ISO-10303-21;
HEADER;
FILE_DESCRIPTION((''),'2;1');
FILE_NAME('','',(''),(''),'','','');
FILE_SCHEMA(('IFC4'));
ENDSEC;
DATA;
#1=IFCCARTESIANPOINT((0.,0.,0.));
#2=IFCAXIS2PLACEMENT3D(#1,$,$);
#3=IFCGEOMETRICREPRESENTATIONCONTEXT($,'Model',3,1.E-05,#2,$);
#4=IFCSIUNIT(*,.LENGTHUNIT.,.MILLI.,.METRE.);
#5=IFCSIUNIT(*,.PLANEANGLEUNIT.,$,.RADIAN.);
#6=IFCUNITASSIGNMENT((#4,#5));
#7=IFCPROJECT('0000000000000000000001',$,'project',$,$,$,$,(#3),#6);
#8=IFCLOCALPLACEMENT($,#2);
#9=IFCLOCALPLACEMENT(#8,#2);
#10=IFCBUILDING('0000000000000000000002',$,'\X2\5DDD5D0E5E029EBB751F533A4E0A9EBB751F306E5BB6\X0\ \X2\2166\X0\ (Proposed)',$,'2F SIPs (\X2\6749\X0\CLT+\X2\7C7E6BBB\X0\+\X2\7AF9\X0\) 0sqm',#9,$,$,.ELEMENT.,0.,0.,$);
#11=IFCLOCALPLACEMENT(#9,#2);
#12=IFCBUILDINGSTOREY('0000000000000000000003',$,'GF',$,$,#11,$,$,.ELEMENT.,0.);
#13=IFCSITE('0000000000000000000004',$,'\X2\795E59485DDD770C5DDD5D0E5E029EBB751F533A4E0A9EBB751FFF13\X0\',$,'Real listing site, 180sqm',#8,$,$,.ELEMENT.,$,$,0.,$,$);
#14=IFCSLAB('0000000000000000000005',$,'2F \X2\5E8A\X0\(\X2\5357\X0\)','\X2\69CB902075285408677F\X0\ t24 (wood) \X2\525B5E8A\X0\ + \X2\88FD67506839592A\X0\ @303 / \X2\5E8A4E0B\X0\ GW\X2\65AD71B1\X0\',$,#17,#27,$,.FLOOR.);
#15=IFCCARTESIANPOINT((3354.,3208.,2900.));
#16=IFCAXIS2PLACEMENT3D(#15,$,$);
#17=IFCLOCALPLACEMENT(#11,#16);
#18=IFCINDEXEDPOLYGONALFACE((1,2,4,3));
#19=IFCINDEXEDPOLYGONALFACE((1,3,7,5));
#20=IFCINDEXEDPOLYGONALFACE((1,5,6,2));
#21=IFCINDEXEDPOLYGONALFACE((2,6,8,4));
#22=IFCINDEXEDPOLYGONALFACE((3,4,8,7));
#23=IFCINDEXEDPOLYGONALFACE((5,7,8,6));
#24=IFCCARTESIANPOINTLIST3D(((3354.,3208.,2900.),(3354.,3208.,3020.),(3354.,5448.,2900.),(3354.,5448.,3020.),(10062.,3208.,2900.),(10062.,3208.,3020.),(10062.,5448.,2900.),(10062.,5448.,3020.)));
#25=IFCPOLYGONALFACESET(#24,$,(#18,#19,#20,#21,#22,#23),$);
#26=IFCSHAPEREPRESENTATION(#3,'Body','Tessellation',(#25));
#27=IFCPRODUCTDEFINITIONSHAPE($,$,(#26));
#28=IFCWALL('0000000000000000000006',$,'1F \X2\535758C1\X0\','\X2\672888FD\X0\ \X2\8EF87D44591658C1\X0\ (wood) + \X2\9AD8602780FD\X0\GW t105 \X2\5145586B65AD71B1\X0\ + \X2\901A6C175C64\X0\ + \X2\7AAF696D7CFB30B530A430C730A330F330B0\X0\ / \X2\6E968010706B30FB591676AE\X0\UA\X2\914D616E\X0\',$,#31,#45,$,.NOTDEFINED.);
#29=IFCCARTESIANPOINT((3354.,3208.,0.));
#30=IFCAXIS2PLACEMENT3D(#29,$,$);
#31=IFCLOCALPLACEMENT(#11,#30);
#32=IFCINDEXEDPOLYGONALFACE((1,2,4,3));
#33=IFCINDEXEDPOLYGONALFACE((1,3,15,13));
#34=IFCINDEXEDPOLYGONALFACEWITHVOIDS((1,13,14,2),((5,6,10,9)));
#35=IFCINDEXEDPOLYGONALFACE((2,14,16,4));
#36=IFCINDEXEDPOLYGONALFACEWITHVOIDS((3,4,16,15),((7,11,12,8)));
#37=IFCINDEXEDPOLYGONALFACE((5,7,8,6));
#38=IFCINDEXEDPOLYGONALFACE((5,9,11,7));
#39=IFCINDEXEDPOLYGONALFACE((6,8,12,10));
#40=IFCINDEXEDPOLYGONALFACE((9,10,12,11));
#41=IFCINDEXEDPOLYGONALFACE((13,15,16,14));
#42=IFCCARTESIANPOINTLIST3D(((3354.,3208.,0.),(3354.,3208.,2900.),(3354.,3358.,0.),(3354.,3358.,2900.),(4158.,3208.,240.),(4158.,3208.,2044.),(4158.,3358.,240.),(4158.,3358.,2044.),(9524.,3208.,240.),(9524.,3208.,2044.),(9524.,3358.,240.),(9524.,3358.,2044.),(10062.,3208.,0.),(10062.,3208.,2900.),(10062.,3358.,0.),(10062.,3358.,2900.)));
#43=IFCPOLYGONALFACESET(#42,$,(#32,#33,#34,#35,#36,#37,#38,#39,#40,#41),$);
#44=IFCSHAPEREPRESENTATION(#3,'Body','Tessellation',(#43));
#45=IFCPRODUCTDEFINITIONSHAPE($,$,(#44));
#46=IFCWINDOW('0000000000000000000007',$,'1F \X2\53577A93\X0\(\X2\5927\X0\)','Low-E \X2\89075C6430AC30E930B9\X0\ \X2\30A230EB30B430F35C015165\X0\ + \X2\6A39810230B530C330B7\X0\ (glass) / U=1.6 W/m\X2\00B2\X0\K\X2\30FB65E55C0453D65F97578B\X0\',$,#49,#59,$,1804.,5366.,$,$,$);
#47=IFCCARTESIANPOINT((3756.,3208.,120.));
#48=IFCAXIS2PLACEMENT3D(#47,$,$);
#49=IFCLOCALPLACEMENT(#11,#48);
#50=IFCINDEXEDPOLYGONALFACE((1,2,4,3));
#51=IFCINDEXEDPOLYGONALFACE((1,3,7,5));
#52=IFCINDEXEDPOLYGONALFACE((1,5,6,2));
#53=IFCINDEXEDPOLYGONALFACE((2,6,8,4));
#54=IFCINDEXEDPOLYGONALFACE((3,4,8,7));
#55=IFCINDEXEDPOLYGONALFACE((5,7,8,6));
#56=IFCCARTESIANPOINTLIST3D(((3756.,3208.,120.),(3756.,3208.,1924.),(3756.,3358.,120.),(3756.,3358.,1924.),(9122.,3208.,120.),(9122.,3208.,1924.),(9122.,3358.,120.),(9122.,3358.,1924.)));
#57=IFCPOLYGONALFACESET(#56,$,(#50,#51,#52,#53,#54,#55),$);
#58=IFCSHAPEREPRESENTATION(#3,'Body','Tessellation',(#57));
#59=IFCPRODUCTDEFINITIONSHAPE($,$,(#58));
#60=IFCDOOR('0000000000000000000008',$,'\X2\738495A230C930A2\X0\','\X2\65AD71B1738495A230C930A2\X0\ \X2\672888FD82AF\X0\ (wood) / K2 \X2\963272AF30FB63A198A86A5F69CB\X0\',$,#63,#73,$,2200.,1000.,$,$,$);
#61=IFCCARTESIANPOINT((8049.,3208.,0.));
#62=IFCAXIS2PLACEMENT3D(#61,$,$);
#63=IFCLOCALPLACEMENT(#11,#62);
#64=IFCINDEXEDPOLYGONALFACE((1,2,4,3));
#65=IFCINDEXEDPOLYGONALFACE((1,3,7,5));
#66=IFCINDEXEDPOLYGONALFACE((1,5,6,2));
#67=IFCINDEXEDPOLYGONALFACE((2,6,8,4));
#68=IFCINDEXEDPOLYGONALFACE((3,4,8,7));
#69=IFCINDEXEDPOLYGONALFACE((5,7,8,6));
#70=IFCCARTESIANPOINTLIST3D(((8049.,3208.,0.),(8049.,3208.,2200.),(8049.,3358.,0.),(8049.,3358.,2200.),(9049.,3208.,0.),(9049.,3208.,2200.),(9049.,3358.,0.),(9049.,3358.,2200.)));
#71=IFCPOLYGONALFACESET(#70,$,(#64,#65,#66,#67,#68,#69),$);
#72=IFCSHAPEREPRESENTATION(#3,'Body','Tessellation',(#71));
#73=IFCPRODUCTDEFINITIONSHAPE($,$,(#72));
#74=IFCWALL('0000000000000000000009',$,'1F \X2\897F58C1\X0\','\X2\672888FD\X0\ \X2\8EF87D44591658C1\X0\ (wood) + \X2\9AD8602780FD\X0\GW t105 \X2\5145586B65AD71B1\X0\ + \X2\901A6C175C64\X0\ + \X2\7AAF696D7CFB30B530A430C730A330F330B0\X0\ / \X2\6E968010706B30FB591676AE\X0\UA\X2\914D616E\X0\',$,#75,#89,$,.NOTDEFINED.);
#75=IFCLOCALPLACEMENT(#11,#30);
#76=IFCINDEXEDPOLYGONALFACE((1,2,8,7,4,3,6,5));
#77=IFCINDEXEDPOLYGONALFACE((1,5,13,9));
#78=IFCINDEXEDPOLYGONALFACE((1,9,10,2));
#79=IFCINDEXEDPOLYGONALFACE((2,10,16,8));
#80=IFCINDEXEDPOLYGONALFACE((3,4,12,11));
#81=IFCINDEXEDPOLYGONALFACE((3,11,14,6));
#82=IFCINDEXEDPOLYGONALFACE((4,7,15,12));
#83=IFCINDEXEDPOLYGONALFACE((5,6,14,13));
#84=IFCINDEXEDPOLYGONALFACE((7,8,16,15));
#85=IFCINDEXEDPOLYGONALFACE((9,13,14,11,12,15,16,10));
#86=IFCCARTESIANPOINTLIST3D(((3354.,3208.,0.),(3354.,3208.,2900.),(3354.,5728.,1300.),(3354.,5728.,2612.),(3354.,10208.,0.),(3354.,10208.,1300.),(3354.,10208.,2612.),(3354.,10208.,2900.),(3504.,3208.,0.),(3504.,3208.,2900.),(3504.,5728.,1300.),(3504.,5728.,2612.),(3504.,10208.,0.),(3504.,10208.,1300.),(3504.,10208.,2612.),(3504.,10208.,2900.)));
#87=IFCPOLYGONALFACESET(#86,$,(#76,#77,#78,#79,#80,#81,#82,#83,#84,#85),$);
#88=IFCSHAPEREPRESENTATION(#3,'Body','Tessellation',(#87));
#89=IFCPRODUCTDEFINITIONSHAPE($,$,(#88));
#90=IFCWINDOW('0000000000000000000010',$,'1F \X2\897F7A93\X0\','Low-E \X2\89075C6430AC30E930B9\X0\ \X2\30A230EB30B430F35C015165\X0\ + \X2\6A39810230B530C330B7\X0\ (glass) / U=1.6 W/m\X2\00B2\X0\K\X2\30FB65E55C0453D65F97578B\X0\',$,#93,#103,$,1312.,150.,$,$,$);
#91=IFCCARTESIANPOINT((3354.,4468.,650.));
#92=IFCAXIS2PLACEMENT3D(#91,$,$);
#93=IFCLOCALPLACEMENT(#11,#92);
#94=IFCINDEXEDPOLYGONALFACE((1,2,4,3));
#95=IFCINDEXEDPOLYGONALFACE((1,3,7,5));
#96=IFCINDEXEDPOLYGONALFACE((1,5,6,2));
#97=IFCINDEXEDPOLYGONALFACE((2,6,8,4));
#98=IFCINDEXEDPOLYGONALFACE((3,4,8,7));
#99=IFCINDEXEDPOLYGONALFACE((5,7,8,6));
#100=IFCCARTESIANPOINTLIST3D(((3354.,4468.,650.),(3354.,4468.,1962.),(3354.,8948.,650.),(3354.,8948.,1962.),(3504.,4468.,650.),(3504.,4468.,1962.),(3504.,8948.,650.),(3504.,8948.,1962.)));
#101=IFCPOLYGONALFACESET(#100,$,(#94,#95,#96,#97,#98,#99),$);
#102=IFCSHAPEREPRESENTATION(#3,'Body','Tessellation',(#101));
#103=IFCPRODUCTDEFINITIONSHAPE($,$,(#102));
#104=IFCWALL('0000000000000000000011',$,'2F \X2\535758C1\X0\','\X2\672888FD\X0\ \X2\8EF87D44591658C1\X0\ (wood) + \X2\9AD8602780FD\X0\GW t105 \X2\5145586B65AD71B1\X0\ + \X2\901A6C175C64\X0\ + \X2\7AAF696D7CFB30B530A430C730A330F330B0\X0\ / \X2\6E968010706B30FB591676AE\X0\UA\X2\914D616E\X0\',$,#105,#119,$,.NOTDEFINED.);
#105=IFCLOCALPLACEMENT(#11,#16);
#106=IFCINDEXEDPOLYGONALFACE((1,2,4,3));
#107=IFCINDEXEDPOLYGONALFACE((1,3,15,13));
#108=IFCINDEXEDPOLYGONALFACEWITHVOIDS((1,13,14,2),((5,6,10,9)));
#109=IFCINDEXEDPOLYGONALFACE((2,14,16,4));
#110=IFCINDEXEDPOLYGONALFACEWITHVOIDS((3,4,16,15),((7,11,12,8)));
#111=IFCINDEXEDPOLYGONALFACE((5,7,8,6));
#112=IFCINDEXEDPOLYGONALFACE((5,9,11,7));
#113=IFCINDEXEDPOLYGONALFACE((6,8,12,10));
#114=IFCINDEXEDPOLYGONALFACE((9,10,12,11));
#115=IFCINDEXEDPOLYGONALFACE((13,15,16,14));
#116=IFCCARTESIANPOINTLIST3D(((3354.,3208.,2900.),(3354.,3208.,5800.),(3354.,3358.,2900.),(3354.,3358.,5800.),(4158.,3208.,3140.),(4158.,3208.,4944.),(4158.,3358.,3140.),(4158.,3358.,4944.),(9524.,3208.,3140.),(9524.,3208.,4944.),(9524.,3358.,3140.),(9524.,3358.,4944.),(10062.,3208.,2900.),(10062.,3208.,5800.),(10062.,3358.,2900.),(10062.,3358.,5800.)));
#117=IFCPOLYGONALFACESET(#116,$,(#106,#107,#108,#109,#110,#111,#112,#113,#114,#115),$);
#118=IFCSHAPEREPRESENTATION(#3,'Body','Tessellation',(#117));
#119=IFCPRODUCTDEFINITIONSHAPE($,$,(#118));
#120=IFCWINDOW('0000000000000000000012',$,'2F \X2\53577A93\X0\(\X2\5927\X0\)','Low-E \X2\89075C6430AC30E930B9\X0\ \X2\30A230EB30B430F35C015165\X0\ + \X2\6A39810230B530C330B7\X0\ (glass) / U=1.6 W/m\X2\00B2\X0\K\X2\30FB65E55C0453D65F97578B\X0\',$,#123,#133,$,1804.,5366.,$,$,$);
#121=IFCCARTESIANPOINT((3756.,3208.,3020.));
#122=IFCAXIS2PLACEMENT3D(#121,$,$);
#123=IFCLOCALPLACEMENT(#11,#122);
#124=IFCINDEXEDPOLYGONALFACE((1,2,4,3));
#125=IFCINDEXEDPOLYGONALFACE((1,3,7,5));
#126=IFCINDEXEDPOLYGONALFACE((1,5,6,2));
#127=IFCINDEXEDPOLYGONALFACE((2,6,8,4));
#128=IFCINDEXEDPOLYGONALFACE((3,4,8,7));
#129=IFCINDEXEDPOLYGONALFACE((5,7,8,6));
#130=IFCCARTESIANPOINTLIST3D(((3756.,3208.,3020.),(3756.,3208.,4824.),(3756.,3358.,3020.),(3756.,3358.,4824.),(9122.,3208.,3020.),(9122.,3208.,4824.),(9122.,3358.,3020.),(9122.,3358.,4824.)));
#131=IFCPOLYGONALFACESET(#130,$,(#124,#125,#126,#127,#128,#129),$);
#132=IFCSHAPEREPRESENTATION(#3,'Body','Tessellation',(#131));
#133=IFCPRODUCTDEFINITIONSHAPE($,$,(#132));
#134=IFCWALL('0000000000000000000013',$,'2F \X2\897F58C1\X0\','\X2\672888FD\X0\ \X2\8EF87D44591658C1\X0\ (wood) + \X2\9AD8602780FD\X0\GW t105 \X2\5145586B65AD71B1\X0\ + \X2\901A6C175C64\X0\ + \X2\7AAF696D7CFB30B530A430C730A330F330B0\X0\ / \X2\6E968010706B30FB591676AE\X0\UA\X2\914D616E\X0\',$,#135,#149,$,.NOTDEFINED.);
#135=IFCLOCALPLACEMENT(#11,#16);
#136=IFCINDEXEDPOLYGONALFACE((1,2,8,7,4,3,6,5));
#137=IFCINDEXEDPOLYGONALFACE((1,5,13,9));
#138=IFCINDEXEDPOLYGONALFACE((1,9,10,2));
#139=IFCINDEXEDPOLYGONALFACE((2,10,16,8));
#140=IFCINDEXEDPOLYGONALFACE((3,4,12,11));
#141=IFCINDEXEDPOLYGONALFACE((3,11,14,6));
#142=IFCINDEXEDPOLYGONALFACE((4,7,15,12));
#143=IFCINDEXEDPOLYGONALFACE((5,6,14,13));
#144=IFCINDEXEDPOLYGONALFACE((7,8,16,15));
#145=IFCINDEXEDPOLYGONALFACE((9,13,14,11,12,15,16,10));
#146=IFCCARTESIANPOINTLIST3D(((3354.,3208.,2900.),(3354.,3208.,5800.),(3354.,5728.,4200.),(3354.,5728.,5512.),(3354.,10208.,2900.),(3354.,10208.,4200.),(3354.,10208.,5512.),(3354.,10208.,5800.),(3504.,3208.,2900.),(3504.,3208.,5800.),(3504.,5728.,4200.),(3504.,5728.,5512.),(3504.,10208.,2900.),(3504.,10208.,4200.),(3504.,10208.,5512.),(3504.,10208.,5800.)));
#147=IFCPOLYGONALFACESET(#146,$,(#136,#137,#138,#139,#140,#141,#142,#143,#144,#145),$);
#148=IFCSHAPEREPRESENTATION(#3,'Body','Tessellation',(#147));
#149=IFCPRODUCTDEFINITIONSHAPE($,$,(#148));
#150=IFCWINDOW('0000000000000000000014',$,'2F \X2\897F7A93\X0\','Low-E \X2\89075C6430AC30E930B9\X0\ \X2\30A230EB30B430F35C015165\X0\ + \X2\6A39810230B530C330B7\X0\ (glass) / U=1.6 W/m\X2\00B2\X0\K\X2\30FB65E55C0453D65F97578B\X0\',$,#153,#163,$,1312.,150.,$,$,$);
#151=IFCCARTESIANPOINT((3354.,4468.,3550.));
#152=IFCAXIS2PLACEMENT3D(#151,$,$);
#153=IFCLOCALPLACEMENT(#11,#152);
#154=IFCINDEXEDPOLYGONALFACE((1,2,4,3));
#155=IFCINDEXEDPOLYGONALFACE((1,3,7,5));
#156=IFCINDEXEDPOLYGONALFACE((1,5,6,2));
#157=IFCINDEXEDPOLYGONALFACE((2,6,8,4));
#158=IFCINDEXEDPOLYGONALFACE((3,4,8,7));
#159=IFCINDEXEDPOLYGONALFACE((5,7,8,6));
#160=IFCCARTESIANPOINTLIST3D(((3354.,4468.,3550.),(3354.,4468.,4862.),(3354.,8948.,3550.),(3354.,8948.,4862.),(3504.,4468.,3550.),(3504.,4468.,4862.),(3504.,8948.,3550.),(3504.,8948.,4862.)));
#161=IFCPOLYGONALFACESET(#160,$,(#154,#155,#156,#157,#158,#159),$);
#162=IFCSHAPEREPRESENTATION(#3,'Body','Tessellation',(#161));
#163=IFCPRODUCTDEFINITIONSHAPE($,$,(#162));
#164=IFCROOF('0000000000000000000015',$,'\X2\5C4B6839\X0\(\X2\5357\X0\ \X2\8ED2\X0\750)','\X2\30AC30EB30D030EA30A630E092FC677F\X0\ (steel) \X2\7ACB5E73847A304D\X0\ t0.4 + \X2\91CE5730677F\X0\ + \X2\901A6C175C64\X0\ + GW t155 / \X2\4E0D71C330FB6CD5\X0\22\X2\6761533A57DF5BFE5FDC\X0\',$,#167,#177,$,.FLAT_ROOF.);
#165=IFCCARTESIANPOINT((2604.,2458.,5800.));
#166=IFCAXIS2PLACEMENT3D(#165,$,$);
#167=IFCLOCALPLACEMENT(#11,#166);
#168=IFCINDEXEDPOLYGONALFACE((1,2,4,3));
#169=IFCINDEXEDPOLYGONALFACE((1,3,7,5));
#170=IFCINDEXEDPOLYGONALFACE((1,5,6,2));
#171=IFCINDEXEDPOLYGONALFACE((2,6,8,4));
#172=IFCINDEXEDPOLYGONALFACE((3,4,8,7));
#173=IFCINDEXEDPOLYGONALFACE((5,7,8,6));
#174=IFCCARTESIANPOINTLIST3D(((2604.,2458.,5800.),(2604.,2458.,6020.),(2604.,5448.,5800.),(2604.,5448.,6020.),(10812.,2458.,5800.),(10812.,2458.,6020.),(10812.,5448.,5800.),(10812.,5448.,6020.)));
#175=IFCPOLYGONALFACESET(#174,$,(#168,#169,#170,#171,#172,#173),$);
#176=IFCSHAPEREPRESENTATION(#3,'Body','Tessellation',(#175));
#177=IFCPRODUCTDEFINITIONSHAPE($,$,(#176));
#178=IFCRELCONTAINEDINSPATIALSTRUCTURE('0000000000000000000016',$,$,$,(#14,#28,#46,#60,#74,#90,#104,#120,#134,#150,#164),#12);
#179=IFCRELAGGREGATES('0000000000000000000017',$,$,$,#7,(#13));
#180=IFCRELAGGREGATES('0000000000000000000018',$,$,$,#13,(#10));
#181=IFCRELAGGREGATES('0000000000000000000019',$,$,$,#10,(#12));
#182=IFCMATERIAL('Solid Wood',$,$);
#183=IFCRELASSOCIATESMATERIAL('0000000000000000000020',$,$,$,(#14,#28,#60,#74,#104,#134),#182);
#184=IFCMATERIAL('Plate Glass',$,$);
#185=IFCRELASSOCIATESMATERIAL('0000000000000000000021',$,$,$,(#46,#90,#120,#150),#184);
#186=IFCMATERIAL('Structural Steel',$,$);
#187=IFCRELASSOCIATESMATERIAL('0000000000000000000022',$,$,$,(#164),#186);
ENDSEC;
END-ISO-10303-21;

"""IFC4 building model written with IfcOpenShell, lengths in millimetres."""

from ifc_helpers import new_model, si_unit, frame, frame_2d, origin, place, context, project, spatial, rectangle, extrude, material, element, fill, save


model = new_model("IFC4")

# Units and contexts
model_context = context("Model", 3, precision=1e-05, world=origin())
ifc_project = project(units=[si_unit("LENGTHUNIT", "METRE", prefix="MILLI"), si_unit("PLANEANGLEUNIT", "RADIAN")], contexts=[model_context])

# Site, building, storey
site_placement = place(None, origin())
site = spatial("IfcSite", under=ifc_project, at=site_placement, Name="神奈川県川崎市麻生区上麻生３", ObjectType="Real listing site, 180sqm", CompositionType="ELEMENT", RefElevation=0.0)
building_placement = place(site_placement, origin())
building = spatial("IfcBuilding", under=site, at=building_placement, Name="川崎市麻生区上麻生の家 Ⅶ (Proposed)", ObjectType="2F SIPs (杉CLT+籾殻+竹) 0sqm", CompositionType="ELEMENT", ElevationOfRefHeight=0.0, ElevationOfTerrain=0.0)
storey_placement = place(building_placement, origin())
storey = spatial("IfcBuildingStorey", under=building, at=storey_placement, Name="GF", CompositionType="ELEMENT", Elevation=0.0)

# Slab
ifc_material_1 = material(Name="Solid Wood")
slab_1_placement = place(storey_placement, frame((3354.0, 3208.0, 2900.0)))
element("IfcSlab", 1, at=slab_1_placement, inside=storey, material=ifc_material_1, Name="2F 床(南)", Description="構造用合板 t24 (wood) 剛床 + 製材根太 @303 / 床下 GW断熱", PredefinedType="FLOOR", context=model_context, shape_type="SweptSolid", body=[
    extrude(rectangle(XDim=6708.0, YDim=2240.0, at=frame_2d((3354.0, 1120.0))), frame((3354.0, 3208.0, 2900.0)), (0.0, 0.0, 1.0), 120.0),
])

# Wall, openings, window, door
wall_1_placement = place(storey_placement, frame((3354.0, 3208.0, 0.0)))
wall_1 = element("IfcWall", 2, at=wall_1_placement, inside=storey, material=ifc_material_1, Name="1F 南壁", Description="木製 軸組外壁 (wood) + 高性能GW t105 充填断熱 + 通気層 + 窯業系サイディング / 準耐火・外皮UA配慮", PredefinedType="NOTDEFINED", context=model_context, shape_type="SweptSolid", body=[
    extrude(rectangle(XDim=6708.0, YDim=150.0, at=frame_2d((3354.0, 75.0))), frame((3354.0, 3208.0, 0.0)), (0.0, 0.0, 1.0), 2900.0),
])
opening_1_placement = place(storey_placement, frame((3756.0, 3208.0, 120.0)))
opening_1 = element("IfcOpeningElement", 3, at=opening_1_placement, cuts=wall_1, PredefinedType="NOTDEFINED", context=model_context, shape_type="SweptSolid", body=[
    extrude(rectangle(XDim=5366.0, YDim=150.0, at=frame_2d((2683.0, 75.0))), frame((3756.0, 3208.0, 120.0)), (0.0, 0.0, 1.0), 1804.0),
])
opening_2_placement = place(storey_placement, frame((8049.0, 3208.0, 0.0)))
opening_2 = element("IfcOpeningElement", 4, at=opening_2_placement, cuts=wall_1, PredefinedType="NOTDEFINED", context=model_context, shape_type="SweptSolid", body=[
    extrude(rectangle(XDim=1000.0, YDim=150.0, at=frame_2d((500.0, 75.0))), frame((8049.0, 3208.0, 0.0)), (0.0, 0.0, 1.0), 2200.0),
])
ifc_material_2 = material(Name="Plate Glass")
window_1_placement = place(storey_placement, frame((3756.0, 3208.0, 120.0)))
window_1 = element("IfcWindow", 5, at=window_1_placement, inside=storey, material=ifc_material_2, Name="1F 南窓(大)", Description="Low-E 複層ガラス アルゴン封入 + 樹脂サッシ (glass) / U=1.6 W/m²K・日射取得型", OverallHeight=1804.0, OverallWidth=5366.0, context=model_context, shape_type="SweptSolid", body=[
    extrude(rectangle(XDim=5366.0, YDim=150.0, at=frame_2d((2683.0, 75.0))), frame((3756.0, 3208.0, 120.0)), (0.0, 0.0, 1.0), 1804.0),
])
fill(opening_1, window_1)
door_placement = place(storey_placement, frame((8049.0, 3208.0, 0.0)))
door = element("IfcDoor", 6, at=door_placement, inside=storey, material=ifc_material_1, Name="玄関ドア", Description="断熱玄関ドア 木製芯 (wood) / K2 防犯・採風機構", OverallHeight=2200.0, OverallWidth=1000.0, context=model_context, shape_type="SweptSolid", body=[
    extrude(rectangle(XDim=1000.0, YDim=150.0, at=frame_2d((500.0, 75.0))), frame((8049.0, 3208.0, 0.0)), (0.0, 0.0, 1.0), 2200.0),
])
fill(opening_2, door)

# Walls, openings, windows
wall_2_placement = place(storey_placement, frame((3354.0, 3208.0, 0.0)))
wall_2 = element("IfcWall", 7, at=wall_2_placement, inside=storey, material=ifc_material_1, Name="1F 西壁", Description="木製 軸組外壁 (wood) + 高性能GW t105 充填断熱 + 通気層 + 窯業系サイディング / 準耐火・外皮UA配慮", PredefinedType="NOTDEFINED", context=model_context, shape_type="SweptSolid", body=[
    extrude(rectangle(XDim=150.0, YDim=7000.0, at=frame_2d((75.0, 3500.0))), frame((3354.0, 3208.0, 0.0)), (0.0, 0.0, 1.0), 2900.0),
])
opening_3_placement = place(storey_placement, frame((3354.0, 4468.0, 650.0)))
opening_3 = element("IfcOpeningElement", 8, at=opening_3_placement, cuts=wall_2, PredefinedType="NOTDEFINED", context=model_context, shape_type="SweptSolid", body=[
    extrude(rectangle(XDim=150.0, YDim=4480.0, at=frame_2d((75.0, 2240.0))), frame((3354.0, 4468.0, 650.0)), (0.0, 0.0, 1.0), 1312.0),
])
window_2_placement = place(storey_placement, frame((3354.0, 4468.0, 650.0)))
window_2 = element("IfcWindow", 9, at=window_2_placement, inside=storey, material=ifc_material_2, Name="1F 西窓", Description="Low-E 複層ガラス アルゴン封入 + 樹脂サッシ (glass) / U=1.6 W/m²K・日射取得型", OverallHeight=1312.0, OverallWidth=150.0, context=model_context, shape_type="SweptSolid", body=[
    extrude(rectangle(XDim=150.0, YDim=4480.0, at=frame_2d((75.0, 2240.0))), frame((3354.0, 4468.0, 650.0)), (0.0, 0.0, 1.0), 1312.0),
])
fill(opening_3, window_2)
wall_3_placement = place(storey_placement, frame((3354.0, 3208.0, 2900.0)))
wall_3 = element("IfcWall", 10, at=wall_3_placement, inside=storey, material=ifc_material_1, Name="2F 南壁", Description="木製 軸組外壁 (wood) + 高性能GW t105 充填断熱 + 通気層 + 窯業系サイディング / 準耐火・外皮UA配慮", PredefinedType="NOTDEFINED", context=model_context, shape_type="SweptSolid", body=[
    extrude(rectangle(XDim=6708.0, YDim=150.0, at=frame_2d((3354.0, 75.0))), frame((3354.0, 3208.0, 2900.0)), (0.0, 0.0, 1.0), 2900.0),
])
opening_4_placement = place(storey_placement, frame((3756.0, 3208.0, 3020.0)))
opening_4 = element("IfcOpeningElement", 11, at=opening_4_placement, cuts=wall_3, PredefinedType="NOTDEFINED", context=model_context, shape_type="SweptSolid", body=[
    extrude(rectangle(XDim=5366.0, YDim=150.0, at=frame_2d((2683.0, 75.0))), frame((3756.0, 3208.0, 3020.0)), (0.0, 0.0, 1.0), 1804.0),
])
window_3_placement = place(storey_placement, frame((3756.0, 3208.0, 3020.0)))
window_3 = element("IfcWindow", 12, at=window_3_placement, inside=storey, material=ifc_material_2, Name="2F 南窓(大)", Description="Low-E 複層ガラス アルゴン封入 + 樹脂サッシ (glass) / U=1.6 W/m²K・日射取得型", OverallHeight=1804.0, OverallWidth=5366.0, context=model_context, shape_type="SweptSolid", body=[
    extrude(rectangle(XDim=5366.0, YDim=150.0, at=frame_2d((2683.0, 75.0))), frame((3756.0, 3208.0, 3020.0)), (0.0, 0.0, 1.0), 1804.0),
])
fill(opening_4, window_3)
wall_4_placement = place(storey_placement, frame((3354.0, 3208.0, 2900.0)))
wall_4 = element("IfcWall", 13, at=wall_4_placement, inside=storey, material=ifc_material_1, Name="2F 西壁", Description="木製 軸組外壁 (wood) + 高性能GW t105 充填断熱 + 通気層 + 窯業系サイディング / 準耐火・外皮UA配慮", PredefinedType="NOTDEFINED", context=model_context, shape_type="SweptSolid", body=[
    extrude(rectangle(XDim=150.0, YDim=7000.0, at=frame_2d((75.0, 3500.0))), frame((3354.0, 3208.0, 2900.0)), (0.0, 0.0, 1.0), 2900.0),
])
opening_5_placement = place(storey_placement, frame((3354.0, 4468.0, 3550.0)))
opening_5 = element("IfcOpeningElement", 14, at=opening_5_placement, cuts=wall_4, PredefinedType="NOTDEFINED", context=model_context, shape_type="SweptSolid", body=[
    extrude(rectangle(XDim=150.0, YDim=4480.0, at=frame_2d((75.0, 2240.0))), frame((3354.0, 4468.0, 3550.0)), (0.0, 0.0, 1.0), 1312.0),
])
window_4_placement = place(storey_placement, frame((3354.0, 4468.0, 3550.0)))
window_4 = element("IfcWindow", 15, at=window_4_placement, inside=storey, material=ifc_material_2, Name="2F 西窓", Description="Low-E 複層ガラス アルゴン封入 + 樹脂サッシ (glass) / U=1.6 W/m²K・日射取得型", OverallHeight=1312.0, OverallWidth=150.0, context=model_context, shape_type="SweptSolid", body=[
    extrude(rectangle(XDim=150.0, YDim=4480.0, at=frame_2d((75.0, 2240.0))), frame((3354.0, 4468.0, 3550.0)), (0.0, 0.0, 1.0), 1312.0),
])
fill(opening_5, window_4)

# Roof
ifc_material_3 = material(Name="Structural Steel")
roof_1_placement = place(storey_placement, frame((2604.0, 2458.0, 5800.0)))
element("IfcRoof", 16, at=roof_1_placement, inside=storey, material=ifc_material_3, Name="屋根(南 軒750)", Description="ガルバリウム鋼板 (steel) 立平葺き t0.4 + 野地板 + 通気層 + GW t155 / 不燃・法22条区域対応", PredefinedType="FLAT_ROOF", context=model_context, shape_type="SweptSolid", body=[
    extrude(rectangle(XDim=8208.0, YDim=2990.0, at=frame_2d((4104.0, 1495.0))), frame((2604.0, 2458.0, 5800.0)), (0.0, 0.0, 1.0), 220.0),
])

save(model, "model.ifc")
